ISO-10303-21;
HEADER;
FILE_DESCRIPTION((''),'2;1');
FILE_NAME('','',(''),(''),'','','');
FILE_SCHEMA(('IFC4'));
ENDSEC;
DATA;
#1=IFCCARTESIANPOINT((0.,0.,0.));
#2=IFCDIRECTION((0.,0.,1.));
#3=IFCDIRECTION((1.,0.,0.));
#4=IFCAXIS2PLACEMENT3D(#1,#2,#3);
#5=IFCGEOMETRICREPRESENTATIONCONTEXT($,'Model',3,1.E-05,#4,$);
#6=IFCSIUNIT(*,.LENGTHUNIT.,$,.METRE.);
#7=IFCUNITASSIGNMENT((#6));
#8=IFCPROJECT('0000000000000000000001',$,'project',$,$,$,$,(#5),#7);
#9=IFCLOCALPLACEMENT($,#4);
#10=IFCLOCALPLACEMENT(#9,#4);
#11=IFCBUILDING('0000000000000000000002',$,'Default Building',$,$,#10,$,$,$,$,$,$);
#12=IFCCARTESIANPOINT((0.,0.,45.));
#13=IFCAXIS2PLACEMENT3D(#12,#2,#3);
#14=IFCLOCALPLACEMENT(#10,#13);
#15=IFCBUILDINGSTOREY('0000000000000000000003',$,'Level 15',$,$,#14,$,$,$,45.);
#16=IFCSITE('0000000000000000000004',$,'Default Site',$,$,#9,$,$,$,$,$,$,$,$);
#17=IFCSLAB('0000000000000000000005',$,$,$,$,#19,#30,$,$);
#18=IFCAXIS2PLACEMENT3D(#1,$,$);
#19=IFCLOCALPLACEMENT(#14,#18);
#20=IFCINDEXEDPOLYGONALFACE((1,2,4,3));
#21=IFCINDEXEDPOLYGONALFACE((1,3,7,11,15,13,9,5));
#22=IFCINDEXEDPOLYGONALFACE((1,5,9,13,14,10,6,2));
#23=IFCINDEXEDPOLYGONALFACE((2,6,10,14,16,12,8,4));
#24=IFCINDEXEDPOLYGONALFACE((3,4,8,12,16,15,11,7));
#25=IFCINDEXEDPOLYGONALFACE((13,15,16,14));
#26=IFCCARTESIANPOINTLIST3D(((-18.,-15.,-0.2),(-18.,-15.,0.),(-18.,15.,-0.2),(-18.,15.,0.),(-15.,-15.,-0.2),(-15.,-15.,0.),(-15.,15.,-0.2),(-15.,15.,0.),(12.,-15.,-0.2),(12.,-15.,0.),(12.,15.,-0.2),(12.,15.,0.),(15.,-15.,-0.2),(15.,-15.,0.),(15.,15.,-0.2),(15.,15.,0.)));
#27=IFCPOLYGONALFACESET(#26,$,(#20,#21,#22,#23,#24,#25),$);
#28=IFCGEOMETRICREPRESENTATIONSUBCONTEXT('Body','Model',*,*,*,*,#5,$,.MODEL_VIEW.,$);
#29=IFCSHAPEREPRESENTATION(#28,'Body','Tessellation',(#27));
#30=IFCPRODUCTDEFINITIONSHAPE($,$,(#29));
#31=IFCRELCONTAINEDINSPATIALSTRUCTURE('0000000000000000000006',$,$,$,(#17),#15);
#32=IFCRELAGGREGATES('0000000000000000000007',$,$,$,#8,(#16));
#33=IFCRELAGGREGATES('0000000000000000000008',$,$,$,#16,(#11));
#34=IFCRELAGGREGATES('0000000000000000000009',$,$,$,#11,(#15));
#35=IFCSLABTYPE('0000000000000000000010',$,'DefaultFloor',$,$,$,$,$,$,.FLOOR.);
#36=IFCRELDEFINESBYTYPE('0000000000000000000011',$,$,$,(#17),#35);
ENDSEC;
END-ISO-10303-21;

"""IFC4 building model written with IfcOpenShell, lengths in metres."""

from ifc_helpers import new_model, si_unit, frame, origin_with_axes, place, context, subcontext, project, spatial, polyline, outline, extrude, type_object, element, save


model = new_model("IFC4")

# Units and contexts
model_context = context("Model", 3, precision=1e-05, world=origin_with_axes())
body_context = subcontext(model_context, "Body", "Model", "MODEL_VIEW")
ifc_project = project(units=[si_unit("LENGTHUNIT", "METRE")], contexts=[model_context])

# Site, building, storey
site_placement = place(None, origin_with_axes())
site = spatial("IfcSite", under=ifc_project, at=site_placement, Name="Default Site")
building_placement = place(site_placement, origin_with_axes())
building = spatial("IfcBuilding", under=site, at=building_placement, Name="Default Building")
storey_placement = place(building_placement, frame((0.0, 0.0, 45.0), z_axis=(0.0, 0.0, 1.0), x_axis=(1.0, 0.0, 0.0)))
storey = spatial("IfcBuildingStorey", under=building, at=storey_placement, Name="Level 15", Elevation=45.0)

# Slab
slab_type = type_object("IfcSlabType", Name="DefaultFloor", PredefinedType="FLOOR")
slab_placement = place(storey_placement, frame((0.0, 0.0, -45.0), z_axis=(0.0, 0.0, 1.0), x_axis=(1.0, 0.0, 0.0)))
element("IfcSlab", 1, at=slab_placement, inside=storey, type_object=slab_type, context=body_context, shape_type="SweptSolid", body=[
    extrude(outline(polyline([(-18.0, -15.0), (-18.0, 15.0), (-15.0, 15.0), (12.0, 15.0), (15.0, 15.0), (15.0, -15.0), (12.0, -15.0), (-15.0, -15.0), (-18.0, -15.0)])), frame((0.0, 0.0, 45.0), z_axis=(0.0, 0.0, 1.0), x_axis=(1.0, 0.0, 0.0)), (0.0, 0.0, -1.0), 0.2),
])

save(model, "model.ifc")
